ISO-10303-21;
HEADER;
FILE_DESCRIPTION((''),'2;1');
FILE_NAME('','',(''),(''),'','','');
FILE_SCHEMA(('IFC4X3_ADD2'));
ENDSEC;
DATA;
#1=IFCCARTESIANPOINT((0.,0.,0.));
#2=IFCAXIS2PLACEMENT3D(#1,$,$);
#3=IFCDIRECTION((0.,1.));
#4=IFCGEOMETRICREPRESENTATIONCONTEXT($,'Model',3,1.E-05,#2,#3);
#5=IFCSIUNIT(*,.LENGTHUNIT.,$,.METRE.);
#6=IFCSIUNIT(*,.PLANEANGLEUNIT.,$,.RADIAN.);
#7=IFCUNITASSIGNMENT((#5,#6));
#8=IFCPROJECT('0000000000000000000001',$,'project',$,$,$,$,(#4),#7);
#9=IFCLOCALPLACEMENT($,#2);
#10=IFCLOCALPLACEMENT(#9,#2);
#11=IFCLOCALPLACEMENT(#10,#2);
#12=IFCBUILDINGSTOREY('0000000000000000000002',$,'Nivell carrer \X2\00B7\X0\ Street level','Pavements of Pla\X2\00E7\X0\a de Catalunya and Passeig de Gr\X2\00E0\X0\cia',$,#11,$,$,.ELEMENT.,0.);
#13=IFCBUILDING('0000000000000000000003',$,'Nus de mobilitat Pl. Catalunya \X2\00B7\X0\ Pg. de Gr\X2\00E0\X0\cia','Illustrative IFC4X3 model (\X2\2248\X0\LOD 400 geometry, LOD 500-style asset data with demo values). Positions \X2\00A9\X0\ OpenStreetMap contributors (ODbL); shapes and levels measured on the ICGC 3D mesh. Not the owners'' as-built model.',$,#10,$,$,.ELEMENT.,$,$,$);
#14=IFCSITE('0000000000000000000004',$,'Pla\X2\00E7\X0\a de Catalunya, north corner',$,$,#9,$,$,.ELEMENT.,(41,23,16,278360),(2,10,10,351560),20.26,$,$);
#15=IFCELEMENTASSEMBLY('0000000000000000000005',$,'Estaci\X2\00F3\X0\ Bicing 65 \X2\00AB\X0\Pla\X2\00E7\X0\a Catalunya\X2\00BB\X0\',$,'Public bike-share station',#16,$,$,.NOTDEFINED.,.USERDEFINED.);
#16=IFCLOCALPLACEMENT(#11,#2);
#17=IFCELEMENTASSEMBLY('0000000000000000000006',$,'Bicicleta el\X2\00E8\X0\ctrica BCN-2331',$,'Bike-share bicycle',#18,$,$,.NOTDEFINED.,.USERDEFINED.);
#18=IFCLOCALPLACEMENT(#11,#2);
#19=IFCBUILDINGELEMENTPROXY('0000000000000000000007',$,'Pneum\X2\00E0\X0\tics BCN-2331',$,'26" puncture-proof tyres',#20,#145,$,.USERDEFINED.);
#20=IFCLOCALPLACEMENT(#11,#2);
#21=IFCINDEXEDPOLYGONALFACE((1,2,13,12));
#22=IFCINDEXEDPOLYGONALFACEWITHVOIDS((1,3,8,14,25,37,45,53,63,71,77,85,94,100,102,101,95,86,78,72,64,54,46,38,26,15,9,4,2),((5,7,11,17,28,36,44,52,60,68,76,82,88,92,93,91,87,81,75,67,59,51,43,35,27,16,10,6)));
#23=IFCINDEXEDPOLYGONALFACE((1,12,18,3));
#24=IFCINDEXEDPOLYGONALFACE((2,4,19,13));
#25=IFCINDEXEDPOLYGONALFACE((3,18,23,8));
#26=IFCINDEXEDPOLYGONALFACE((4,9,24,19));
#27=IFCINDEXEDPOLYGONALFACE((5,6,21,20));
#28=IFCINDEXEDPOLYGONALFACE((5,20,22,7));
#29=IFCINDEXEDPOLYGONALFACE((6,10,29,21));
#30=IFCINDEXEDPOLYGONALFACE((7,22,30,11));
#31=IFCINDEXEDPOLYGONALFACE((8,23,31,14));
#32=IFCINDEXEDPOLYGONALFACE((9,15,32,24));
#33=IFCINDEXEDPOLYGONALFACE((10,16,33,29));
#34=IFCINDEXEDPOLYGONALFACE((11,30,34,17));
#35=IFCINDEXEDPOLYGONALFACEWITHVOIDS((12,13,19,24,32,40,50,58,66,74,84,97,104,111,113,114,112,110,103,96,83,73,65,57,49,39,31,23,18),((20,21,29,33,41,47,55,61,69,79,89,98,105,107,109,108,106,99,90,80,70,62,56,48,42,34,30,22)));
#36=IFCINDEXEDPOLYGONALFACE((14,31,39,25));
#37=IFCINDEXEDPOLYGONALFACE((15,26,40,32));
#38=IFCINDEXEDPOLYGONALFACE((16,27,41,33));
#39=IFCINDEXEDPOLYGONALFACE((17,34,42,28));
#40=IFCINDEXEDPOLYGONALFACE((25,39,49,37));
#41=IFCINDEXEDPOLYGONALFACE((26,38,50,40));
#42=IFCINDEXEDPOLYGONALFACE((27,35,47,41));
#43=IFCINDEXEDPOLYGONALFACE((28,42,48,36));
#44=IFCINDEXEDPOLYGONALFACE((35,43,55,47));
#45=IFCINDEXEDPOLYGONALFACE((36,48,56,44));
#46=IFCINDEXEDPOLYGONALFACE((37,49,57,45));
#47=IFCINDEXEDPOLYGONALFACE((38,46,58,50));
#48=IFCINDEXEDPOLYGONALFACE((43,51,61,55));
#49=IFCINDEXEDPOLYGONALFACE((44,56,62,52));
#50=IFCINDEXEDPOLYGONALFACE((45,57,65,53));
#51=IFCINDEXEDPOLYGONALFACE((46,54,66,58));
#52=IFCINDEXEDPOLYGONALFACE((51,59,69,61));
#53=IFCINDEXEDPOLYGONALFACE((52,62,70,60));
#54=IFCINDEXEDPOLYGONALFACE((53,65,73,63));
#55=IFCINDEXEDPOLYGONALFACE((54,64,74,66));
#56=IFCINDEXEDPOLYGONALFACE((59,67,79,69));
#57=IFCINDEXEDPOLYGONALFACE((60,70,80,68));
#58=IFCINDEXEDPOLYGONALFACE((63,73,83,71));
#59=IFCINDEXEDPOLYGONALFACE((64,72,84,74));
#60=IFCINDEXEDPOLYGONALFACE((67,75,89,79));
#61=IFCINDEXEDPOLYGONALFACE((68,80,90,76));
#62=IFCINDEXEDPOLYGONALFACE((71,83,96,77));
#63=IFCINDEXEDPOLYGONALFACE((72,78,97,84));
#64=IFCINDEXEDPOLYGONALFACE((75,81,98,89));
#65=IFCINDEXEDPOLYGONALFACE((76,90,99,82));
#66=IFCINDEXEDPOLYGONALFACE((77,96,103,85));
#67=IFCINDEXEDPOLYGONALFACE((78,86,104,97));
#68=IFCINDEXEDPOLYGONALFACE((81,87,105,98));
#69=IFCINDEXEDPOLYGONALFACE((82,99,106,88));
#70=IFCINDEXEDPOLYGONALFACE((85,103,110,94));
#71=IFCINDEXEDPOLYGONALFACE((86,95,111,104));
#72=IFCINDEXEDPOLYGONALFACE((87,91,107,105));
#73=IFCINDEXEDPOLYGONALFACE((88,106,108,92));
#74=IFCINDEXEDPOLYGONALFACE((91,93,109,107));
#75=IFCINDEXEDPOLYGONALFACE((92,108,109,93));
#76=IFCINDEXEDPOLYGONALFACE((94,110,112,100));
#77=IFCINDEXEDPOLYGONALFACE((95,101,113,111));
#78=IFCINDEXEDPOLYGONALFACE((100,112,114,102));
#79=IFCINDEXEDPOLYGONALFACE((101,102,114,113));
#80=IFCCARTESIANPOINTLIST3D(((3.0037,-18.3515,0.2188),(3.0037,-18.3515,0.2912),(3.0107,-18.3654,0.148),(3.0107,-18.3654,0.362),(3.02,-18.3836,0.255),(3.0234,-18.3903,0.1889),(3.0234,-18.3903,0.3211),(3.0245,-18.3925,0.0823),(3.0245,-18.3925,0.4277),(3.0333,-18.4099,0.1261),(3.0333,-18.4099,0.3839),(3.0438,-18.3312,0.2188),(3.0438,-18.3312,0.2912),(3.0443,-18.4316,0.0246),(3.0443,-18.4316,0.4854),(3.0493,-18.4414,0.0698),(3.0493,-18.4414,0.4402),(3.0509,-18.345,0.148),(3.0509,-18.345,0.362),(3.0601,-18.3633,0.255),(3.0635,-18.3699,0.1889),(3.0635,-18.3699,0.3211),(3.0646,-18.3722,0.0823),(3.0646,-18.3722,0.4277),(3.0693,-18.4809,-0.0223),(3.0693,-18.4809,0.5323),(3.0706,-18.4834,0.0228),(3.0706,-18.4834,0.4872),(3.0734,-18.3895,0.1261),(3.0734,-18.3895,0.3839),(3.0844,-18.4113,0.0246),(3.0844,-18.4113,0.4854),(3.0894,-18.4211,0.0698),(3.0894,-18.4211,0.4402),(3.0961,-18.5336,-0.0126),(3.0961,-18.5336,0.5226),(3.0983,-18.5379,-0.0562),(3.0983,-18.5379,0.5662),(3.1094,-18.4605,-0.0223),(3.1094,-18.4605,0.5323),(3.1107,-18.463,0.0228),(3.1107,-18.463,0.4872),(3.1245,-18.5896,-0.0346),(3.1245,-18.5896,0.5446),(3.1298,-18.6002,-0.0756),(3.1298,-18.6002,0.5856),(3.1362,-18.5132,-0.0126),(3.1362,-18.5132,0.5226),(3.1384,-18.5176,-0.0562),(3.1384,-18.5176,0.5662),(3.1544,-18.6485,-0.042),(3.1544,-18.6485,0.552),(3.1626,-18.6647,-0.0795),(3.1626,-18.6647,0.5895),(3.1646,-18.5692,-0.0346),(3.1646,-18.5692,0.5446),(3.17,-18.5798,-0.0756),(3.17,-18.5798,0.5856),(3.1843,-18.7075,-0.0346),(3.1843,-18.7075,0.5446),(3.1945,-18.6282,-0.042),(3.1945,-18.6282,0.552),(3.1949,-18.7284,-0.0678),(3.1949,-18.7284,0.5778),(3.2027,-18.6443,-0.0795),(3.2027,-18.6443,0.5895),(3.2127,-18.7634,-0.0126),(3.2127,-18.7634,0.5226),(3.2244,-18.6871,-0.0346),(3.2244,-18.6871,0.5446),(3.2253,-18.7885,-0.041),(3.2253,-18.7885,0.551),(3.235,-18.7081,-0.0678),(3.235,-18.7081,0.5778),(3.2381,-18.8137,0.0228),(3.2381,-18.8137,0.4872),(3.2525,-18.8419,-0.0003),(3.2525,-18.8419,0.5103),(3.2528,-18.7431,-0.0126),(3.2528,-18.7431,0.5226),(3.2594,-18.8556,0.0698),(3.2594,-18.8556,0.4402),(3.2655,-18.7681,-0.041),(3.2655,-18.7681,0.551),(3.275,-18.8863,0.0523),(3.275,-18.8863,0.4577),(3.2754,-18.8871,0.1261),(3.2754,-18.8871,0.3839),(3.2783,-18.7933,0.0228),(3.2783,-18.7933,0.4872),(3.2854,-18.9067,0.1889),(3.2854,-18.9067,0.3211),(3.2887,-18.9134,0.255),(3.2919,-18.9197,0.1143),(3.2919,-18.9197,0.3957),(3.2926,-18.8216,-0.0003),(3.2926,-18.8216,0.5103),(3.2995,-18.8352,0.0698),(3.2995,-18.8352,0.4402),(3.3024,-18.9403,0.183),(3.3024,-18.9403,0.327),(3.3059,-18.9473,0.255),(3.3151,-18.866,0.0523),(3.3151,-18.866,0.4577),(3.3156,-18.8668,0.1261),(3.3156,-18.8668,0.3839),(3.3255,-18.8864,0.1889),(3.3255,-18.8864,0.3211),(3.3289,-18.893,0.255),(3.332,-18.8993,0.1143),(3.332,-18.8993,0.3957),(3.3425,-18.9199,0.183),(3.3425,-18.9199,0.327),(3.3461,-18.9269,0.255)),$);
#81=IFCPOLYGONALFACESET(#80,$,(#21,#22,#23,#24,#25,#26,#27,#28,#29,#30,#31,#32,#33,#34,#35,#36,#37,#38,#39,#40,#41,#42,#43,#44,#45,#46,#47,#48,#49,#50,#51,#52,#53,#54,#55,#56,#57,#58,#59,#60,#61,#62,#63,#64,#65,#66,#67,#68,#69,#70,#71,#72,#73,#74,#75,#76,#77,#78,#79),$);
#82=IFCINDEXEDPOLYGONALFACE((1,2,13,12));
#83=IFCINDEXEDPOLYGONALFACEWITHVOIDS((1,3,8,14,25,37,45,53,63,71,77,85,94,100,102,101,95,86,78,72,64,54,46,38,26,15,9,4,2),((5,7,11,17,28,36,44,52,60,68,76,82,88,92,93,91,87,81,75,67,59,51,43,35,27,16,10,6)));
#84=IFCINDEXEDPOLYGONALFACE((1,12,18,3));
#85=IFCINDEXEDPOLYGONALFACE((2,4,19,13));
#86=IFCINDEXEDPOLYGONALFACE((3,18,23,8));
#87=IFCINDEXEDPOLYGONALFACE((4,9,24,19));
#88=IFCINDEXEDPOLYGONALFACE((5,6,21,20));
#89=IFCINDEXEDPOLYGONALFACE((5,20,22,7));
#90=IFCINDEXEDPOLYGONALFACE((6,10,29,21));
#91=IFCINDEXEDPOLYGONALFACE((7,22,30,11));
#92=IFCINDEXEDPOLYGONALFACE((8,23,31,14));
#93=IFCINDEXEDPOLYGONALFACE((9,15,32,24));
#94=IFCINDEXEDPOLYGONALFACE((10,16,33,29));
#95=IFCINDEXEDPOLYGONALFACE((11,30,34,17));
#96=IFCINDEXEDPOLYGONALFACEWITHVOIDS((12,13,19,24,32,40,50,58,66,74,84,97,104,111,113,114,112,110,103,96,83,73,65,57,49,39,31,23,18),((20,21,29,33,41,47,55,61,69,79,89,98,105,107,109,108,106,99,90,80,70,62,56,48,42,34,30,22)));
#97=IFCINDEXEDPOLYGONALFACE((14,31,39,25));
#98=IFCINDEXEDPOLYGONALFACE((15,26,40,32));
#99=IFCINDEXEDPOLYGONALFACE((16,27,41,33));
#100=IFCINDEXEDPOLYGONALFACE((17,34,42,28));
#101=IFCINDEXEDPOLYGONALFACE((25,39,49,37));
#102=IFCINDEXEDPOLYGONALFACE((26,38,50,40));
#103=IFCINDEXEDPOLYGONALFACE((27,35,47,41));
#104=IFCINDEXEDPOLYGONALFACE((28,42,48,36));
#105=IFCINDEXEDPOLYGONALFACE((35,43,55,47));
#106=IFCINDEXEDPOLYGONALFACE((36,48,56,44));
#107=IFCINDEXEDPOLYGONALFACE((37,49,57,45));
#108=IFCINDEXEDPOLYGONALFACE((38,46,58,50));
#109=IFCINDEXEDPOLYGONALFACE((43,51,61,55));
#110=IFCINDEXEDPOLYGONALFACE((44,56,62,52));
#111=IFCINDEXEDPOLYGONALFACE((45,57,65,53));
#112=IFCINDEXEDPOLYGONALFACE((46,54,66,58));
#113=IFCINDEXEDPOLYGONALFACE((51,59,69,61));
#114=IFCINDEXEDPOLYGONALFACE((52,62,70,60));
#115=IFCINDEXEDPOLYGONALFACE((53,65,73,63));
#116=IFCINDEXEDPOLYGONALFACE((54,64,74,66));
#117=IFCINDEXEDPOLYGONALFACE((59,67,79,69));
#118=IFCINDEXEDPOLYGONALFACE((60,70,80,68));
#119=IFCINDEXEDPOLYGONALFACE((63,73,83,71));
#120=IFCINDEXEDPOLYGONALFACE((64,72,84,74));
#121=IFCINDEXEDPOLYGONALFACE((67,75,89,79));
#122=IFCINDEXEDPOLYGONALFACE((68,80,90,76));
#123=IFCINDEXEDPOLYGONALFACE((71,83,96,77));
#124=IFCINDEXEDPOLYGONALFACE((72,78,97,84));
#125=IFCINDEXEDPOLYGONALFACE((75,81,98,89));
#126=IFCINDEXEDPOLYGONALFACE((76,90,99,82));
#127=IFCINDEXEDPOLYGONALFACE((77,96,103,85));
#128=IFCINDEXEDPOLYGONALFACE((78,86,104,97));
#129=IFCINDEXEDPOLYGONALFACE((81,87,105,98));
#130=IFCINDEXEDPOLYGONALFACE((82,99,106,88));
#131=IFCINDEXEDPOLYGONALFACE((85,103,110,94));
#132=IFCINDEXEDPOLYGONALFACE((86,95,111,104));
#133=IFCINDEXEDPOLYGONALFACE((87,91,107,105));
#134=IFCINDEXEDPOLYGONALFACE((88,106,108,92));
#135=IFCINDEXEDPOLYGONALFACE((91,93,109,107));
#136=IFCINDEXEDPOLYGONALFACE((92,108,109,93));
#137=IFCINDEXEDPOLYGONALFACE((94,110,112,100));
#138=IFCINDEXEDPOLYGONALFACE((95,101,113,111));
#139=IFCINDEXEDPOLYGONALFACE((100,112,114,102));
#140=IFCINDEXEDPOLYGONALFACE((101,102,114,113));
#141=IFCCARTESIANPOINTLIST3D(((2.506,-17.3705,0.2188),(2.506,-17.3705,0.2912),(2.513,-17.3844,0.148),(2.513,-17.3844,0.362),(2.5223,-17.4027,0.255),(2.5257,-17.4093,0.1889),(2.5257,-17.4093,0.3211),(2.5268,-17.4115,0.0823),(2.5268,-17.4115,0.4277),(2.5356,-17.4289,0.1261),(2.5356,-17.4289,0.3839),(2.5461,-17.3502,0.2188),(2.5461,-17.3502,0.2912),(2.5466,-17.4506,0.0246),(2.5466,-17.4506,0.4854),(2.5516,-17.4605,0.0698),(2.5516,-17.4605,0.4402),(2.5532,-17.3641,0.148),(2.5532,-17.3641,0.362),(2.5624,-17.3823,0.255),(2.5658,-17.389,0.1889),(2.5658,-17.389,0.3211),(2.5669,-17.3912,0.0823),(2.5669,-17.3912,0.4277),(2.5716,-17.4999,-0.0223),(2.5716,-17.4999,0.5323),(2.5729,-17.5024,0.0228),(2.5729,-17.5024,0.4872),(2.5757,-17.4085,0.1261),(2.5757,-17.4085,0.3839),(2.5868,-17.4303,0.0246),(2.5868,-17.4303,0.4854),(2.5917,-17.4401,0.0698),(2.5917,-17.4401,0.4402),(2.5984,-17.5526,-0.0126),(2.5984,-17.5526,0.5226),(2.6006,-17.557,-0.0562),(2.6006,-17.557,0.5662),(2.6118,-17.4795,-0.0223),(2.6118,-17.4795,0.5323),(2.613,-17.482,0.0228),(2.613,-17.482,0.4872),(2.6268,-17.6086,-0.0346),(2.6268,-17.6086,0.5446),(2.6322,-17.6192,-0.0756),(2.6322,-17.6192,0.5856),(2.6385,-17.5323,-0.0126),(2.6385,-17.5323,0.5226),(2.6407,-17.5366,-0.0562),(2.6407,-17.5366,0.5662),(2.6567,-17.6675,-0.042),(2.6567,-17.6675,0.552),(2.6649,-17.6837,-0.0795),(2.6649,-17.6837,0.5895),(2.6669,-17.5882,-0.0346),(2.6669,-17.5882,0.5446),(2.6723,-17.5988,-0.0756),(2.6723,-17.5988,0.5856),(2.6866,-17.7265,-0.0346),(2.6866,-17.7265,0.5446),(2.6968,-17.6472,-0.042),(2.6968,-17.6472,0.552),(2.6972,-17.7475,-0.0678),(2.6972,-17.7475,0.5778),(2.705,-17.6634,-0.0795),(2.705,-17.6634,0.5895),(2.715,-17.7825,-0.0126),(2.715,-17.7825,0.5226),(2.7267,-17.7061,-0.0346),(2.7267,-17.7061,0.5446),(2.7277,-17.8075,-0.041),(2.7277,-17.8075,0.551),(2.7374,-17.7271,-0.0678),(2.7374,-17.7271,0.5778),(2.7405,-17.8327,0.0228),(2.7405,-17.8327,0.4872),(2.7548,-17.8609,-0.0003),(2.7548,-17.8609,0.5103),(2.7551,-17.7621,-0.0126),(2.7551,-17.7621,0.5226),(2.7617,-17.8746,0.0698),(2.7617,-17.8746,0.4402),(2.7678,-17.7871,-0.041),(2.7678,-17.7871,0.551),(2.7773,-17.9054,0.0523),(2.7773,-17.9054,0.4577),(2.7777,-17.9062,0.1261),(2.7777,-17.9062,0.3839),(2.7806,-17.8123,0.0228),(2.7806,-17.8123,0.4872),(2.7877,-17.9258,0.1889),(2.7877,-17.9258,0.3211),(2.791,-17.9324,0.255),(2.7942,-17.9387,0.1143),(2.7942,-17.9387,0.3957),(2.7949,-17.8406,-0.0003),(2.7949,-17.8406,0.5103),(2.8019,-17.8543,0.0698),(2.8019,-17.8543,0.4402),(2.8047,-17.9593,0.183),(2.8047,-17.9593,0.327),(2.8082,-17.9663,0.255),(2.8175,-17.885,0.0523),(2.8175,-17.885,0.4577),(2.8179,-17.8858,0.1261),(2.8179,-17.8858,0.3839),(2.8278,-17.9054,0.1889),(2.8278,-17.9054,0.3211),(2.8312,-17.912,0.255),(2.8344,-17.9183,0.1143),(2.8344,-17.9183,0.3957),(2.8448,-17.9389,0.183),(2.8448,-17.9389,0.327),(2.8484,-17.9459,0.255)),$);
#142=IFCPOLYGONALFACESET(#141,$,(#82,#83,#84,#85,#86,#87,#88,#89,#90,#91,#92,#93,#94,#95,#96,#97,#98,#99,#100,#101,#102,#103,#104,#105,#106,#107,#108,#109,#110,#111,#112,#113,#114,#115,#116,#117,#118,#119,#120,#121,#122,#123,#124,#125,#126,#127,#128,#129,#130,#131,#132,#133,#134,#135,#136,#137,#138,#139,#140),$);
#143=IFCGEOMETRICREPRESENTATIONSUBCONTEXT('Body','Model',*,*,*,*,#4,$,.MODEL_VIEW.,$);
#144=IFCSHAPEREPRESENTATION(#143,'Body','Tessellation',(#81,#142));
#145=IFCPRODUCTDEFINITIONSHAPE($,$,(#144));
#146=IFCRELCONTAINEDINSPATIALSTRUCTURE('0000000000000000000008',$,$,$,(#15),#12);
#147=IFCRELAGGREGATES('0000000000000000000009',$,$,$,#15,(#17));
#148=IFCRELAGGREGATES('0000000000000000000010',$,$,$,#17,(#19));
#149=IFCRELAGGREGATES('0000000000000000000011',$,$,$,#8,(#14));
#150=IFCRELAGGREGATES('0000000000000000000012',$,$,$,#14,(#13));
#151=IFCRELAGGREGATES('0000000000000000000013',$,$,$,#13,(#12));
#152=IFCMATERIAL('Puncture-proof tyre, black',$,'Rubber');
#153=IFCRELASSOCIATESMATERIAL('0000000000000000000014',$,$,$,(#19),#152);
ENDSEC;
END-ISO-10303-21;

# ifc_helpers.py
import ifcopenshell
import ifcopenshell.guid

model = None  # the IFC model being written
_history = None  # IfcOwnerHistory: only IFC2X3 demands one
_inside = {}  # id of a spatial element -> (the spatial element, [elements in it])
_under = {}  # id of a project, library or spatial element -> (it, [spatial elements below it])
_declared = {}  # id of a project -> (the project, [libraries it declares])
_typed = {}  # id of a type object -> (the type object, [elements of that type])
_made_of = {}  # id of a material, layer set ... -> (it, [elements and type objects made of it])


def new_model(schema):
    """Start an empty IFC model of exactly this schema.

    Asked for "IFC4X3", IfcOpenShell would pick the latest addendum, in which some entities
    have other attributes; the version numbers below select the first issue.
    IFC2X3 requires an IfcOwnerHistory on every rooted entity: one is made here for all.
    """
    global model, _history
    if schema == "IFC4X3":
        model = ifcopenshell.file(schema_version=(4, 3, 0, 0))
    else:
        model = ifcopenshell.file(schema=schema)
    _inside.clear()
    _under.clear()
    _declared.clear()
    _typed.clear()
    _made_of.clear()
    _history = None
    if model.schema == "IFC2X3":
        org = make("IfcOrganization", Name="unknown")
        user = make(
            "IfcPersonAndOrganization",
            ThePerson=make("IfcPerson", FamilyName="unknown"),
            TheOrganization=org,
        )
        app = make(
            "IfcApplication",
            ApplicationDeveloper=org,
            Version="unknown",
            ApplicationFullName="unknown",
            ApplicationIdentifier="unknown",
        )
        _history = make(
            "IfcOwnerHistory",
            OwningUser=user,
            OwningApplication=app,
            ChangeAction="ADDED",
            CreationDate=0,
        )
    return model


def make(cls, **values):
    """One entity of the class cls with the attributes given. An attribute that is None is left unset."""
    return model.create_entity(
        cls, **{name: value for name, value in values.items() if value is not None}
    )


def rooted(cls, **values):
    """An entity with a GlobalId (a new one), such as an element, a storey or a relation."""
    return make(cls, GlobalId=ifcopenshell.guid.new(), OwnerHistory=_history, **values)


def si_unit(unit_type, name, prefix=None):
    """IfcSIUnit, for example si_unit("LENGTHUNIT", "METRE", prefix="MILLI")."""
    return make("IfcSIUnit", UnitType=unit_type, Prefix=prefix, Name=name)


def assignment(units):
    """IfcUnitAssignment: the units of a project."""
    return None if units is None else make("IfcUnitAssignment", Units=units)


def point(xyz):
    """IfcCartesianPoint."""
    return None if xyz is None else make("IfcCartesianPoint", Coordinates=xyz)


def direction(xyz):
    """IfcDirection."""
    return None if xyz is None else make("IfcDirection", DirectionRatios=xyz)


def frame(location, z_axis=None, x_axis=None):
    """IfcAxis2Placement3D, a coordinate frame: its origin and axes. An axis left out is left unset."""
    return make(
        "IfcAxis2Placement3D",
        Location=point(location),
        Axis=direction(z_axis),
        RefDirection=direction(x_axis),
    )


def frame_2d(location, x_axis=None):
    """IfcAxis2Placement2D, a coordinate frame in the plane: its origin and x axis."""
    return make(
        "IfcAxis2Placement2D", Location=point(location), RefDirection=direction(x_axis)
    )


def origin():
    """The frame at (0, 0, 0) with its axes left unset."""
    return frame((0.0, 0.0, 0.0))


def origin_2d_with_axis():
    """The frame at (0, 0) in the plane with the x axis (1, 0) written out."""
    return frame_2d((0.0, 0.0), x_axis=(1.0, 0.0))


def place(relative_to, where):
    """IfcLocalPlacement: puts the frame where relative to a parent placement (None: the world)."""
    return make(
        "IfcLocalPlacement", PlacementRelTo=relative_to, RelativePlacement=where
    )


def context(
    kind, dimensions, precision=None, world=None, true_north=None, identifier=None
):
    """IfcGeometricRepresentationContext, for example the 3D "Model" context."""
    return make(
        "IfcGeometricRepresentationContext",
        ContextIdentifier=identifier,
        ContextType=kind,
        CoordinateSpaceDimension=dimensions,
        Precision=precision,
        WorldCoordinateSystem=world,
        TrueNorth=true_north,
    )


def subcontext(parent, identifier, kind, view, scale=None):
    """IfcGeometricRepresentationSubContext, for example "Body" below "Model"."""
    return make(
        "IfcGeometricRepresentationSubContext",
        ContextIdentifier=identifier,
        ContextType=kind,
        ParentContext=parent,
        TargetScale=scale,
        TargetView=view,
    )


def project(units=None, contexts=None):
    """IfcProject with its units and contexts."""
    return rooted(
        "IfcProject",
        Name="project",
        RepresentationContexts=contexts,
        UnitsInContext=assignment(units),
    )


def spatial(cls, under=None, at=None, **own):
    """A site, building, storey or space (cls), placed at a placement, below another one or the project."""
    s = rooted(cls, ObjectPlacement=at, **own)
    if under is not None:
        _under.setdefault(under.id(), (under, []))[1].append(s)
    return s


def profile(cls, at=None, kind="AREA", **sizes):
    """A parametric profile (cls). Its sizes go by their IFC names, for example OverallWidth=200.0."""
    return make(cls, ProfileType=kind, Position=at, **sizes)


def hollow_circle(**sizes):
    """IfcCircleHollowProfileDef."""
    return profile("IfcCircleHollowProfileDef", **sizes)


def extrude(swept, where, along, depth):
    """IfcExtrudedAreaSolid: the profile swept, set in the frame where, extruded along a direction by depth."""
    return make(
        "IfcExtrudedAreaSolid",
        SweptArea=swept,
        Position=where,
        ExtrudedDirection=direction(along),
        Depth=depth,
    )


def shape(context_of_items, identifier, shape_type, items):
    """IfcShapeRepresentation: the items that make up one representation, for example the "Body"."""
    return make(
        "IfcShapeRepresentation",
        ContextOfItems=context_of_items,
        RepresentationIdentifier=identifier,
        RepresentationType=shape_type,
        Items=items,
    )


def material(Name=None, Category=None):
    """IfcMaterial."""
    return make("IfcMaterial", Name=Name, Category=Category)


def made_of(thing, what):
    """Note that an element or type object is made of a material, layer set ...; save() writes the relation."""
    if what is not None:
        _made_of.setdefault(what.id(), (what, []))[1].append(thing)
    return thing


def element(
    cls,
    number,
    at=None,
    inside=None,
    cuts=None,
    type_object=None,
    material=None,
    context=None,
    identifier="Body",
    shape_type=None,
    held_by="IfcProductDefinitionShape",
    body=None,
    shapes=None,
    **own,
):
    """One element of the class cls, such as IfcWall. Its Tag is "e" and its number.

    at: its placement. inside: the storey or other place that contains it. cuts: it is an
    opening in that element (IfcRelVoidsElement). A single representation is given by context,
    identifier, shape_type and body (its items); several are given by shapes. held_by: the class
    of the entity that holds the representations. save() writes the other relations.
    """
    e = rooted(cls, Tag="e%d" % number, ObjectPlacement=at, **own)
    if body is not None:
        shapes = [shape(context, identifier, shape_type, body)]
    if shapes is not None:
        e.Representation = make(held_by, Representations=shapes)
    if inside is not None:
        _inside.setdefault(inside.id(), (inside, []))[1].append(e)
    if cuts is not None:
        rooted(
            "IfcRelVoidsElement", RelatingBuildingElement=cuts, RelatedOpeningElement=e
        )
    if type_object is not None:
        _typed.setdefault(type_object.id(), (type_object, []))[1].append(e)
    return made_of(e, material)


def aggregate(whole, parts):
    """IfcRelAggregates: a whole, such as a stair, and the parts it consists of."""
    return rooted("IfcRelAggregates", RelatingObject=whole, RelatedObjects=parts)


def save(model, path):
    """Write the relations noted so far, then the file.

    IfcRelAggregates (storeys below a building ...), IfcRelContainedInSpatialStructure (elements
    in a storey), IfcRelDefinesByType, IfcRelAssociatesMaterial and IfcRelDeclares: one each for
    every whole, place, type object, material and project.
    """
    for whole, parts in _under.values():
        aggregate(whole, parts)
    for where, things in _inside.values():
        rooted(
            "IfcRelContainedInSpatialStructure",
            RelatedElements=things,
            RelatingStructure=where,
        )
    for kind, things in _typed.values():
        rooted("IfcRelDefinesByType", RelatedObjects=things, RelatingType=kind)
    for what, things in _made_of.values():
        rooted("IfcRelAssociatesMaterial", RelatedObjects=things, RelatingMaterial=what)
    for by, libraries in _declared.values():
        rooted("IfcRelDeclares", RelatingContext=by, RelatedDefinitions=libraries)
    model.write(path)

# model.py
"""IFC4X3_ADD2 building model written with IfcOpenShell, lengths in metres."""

from ifc_helpers import new_model, si_unit, direction, frame, origin, origin_2d_with_axis, place, context, subcontext, project, spatial, hollow_circle, extrude, material, element, aggregate, save


model = new_model("IFC4X3_ADD2")

# Units and contexts
model_context = context("Model", 3, precision=1e-05, world=origin(), true_north=direction((0.0, 1.0)))
body_context = subcontext(model_context, "Body", "Model", "MODEL_VIEW")
ifc_project = project(units=[si_unit("LENGTHUNIT", "METRE"), si_unit("PLANEANGLEUNIT", "RADIAN")], contexts=[model_context])

# Site, building, storey
site_placement = place(None, origin())
site = spatial("IfcSite", under=ifc_project, at=site_placement, Name="Plaça de Catalunya, north corner", CompositionType="ELEMENT", RefLatitude=(41, 23, 16, 278360), RefLongitude=(2, 10, 10, 351560), RefElevation=20.26)
building_placement = place(site_placement, origin())
building = spatial("IfcBuilding", under=site, at=building_placement, Name="Nus de mobilitat Pl. Catalunya · Pg. de Gràcia", Description="Illustrative IFC4X3 model (≈LOD 400 geometry, LOD 500-style asset data with demo values). Positions © OpenStreetMap contributors (ODbL); shapes and levels measured on the ICGC 3D mesh. Not the owners' as-built model.", CompositionType="ELEMENT")
storey_placement = place(building_placement, origin())
storey = spatial("IfcBuildingStorey", under=building, at=storey_placement, Name="Nivell carrer · Street level", Description="Pavements of Plaça de Catalunya and Passeig de Gràcia", CompositionType="ELEMENT", Elevation=0.0)

# Element assemblies, building element proxy
assembly_1_placement = place(building_placement, origin())
assembly_1 = element("IfcElementAssembly", 1, at=assembly_1_placement, inside=storey, Name="Estació Bicing 65 «Plaça Catalunya»", ObjectType="Public bike-share station", AssemblyPlace="NOTDEFINED", PredefinedType="USERDEFINED")
ifc_material_1 = material(Name="Puncture-proof tyre, black", Category="Rubber")
assembly_2_placement = place(building_placement, origin())
assembly_2 = element("IfcElementAssembly", 2, at=assembly_2_placement, Name="Bicicleta elèctrica BCN-2331", ObjectType="Bike-share bicycle", AssemblyPlace="NOTDEFINED", PredefinedType="USERDEFINED")
aggregate(assembly_1, [assembly_2])
proxy_1_placement = place(building_placement, origin())
proxy_1 = element("IfcBuildingElementProxy", 3, at=proxy_1_placement, material=ifc_material_1, Name="Pneumàtics BCN-2331", ObjectType="26\" puncture-proof tyres", PredefinedType="USERDEFINED", context=body_context, shape_type="SweptSolid", body=[
    extrude(hollow_circle(Radius=0.335, WallThickness=0.038, at=origin_2d_with_axis()), frame((3.1544, -18.6485, 0.255), z_axis=(0.891798, 0.452435, 0.0), x_axis=(0.452435, -0.891798, 0.0)), (0.0, 0.0, 1.0), 0.045),
    extrude(hollow_circle(Radius=0.335, WallThickness=0.038, at=origin_2d_with_axis()), frame((2.6567, -17.6675, 0.255), z_axis=(0.891798, 0.452435, 0.0), x_axis=(0.452435, -0.891798, 0.0)), (0.0, 0.0, 1.0), 0.045),
])
aggregate(assembly_2, [proxy_1])

save(model, "model.ifc")
